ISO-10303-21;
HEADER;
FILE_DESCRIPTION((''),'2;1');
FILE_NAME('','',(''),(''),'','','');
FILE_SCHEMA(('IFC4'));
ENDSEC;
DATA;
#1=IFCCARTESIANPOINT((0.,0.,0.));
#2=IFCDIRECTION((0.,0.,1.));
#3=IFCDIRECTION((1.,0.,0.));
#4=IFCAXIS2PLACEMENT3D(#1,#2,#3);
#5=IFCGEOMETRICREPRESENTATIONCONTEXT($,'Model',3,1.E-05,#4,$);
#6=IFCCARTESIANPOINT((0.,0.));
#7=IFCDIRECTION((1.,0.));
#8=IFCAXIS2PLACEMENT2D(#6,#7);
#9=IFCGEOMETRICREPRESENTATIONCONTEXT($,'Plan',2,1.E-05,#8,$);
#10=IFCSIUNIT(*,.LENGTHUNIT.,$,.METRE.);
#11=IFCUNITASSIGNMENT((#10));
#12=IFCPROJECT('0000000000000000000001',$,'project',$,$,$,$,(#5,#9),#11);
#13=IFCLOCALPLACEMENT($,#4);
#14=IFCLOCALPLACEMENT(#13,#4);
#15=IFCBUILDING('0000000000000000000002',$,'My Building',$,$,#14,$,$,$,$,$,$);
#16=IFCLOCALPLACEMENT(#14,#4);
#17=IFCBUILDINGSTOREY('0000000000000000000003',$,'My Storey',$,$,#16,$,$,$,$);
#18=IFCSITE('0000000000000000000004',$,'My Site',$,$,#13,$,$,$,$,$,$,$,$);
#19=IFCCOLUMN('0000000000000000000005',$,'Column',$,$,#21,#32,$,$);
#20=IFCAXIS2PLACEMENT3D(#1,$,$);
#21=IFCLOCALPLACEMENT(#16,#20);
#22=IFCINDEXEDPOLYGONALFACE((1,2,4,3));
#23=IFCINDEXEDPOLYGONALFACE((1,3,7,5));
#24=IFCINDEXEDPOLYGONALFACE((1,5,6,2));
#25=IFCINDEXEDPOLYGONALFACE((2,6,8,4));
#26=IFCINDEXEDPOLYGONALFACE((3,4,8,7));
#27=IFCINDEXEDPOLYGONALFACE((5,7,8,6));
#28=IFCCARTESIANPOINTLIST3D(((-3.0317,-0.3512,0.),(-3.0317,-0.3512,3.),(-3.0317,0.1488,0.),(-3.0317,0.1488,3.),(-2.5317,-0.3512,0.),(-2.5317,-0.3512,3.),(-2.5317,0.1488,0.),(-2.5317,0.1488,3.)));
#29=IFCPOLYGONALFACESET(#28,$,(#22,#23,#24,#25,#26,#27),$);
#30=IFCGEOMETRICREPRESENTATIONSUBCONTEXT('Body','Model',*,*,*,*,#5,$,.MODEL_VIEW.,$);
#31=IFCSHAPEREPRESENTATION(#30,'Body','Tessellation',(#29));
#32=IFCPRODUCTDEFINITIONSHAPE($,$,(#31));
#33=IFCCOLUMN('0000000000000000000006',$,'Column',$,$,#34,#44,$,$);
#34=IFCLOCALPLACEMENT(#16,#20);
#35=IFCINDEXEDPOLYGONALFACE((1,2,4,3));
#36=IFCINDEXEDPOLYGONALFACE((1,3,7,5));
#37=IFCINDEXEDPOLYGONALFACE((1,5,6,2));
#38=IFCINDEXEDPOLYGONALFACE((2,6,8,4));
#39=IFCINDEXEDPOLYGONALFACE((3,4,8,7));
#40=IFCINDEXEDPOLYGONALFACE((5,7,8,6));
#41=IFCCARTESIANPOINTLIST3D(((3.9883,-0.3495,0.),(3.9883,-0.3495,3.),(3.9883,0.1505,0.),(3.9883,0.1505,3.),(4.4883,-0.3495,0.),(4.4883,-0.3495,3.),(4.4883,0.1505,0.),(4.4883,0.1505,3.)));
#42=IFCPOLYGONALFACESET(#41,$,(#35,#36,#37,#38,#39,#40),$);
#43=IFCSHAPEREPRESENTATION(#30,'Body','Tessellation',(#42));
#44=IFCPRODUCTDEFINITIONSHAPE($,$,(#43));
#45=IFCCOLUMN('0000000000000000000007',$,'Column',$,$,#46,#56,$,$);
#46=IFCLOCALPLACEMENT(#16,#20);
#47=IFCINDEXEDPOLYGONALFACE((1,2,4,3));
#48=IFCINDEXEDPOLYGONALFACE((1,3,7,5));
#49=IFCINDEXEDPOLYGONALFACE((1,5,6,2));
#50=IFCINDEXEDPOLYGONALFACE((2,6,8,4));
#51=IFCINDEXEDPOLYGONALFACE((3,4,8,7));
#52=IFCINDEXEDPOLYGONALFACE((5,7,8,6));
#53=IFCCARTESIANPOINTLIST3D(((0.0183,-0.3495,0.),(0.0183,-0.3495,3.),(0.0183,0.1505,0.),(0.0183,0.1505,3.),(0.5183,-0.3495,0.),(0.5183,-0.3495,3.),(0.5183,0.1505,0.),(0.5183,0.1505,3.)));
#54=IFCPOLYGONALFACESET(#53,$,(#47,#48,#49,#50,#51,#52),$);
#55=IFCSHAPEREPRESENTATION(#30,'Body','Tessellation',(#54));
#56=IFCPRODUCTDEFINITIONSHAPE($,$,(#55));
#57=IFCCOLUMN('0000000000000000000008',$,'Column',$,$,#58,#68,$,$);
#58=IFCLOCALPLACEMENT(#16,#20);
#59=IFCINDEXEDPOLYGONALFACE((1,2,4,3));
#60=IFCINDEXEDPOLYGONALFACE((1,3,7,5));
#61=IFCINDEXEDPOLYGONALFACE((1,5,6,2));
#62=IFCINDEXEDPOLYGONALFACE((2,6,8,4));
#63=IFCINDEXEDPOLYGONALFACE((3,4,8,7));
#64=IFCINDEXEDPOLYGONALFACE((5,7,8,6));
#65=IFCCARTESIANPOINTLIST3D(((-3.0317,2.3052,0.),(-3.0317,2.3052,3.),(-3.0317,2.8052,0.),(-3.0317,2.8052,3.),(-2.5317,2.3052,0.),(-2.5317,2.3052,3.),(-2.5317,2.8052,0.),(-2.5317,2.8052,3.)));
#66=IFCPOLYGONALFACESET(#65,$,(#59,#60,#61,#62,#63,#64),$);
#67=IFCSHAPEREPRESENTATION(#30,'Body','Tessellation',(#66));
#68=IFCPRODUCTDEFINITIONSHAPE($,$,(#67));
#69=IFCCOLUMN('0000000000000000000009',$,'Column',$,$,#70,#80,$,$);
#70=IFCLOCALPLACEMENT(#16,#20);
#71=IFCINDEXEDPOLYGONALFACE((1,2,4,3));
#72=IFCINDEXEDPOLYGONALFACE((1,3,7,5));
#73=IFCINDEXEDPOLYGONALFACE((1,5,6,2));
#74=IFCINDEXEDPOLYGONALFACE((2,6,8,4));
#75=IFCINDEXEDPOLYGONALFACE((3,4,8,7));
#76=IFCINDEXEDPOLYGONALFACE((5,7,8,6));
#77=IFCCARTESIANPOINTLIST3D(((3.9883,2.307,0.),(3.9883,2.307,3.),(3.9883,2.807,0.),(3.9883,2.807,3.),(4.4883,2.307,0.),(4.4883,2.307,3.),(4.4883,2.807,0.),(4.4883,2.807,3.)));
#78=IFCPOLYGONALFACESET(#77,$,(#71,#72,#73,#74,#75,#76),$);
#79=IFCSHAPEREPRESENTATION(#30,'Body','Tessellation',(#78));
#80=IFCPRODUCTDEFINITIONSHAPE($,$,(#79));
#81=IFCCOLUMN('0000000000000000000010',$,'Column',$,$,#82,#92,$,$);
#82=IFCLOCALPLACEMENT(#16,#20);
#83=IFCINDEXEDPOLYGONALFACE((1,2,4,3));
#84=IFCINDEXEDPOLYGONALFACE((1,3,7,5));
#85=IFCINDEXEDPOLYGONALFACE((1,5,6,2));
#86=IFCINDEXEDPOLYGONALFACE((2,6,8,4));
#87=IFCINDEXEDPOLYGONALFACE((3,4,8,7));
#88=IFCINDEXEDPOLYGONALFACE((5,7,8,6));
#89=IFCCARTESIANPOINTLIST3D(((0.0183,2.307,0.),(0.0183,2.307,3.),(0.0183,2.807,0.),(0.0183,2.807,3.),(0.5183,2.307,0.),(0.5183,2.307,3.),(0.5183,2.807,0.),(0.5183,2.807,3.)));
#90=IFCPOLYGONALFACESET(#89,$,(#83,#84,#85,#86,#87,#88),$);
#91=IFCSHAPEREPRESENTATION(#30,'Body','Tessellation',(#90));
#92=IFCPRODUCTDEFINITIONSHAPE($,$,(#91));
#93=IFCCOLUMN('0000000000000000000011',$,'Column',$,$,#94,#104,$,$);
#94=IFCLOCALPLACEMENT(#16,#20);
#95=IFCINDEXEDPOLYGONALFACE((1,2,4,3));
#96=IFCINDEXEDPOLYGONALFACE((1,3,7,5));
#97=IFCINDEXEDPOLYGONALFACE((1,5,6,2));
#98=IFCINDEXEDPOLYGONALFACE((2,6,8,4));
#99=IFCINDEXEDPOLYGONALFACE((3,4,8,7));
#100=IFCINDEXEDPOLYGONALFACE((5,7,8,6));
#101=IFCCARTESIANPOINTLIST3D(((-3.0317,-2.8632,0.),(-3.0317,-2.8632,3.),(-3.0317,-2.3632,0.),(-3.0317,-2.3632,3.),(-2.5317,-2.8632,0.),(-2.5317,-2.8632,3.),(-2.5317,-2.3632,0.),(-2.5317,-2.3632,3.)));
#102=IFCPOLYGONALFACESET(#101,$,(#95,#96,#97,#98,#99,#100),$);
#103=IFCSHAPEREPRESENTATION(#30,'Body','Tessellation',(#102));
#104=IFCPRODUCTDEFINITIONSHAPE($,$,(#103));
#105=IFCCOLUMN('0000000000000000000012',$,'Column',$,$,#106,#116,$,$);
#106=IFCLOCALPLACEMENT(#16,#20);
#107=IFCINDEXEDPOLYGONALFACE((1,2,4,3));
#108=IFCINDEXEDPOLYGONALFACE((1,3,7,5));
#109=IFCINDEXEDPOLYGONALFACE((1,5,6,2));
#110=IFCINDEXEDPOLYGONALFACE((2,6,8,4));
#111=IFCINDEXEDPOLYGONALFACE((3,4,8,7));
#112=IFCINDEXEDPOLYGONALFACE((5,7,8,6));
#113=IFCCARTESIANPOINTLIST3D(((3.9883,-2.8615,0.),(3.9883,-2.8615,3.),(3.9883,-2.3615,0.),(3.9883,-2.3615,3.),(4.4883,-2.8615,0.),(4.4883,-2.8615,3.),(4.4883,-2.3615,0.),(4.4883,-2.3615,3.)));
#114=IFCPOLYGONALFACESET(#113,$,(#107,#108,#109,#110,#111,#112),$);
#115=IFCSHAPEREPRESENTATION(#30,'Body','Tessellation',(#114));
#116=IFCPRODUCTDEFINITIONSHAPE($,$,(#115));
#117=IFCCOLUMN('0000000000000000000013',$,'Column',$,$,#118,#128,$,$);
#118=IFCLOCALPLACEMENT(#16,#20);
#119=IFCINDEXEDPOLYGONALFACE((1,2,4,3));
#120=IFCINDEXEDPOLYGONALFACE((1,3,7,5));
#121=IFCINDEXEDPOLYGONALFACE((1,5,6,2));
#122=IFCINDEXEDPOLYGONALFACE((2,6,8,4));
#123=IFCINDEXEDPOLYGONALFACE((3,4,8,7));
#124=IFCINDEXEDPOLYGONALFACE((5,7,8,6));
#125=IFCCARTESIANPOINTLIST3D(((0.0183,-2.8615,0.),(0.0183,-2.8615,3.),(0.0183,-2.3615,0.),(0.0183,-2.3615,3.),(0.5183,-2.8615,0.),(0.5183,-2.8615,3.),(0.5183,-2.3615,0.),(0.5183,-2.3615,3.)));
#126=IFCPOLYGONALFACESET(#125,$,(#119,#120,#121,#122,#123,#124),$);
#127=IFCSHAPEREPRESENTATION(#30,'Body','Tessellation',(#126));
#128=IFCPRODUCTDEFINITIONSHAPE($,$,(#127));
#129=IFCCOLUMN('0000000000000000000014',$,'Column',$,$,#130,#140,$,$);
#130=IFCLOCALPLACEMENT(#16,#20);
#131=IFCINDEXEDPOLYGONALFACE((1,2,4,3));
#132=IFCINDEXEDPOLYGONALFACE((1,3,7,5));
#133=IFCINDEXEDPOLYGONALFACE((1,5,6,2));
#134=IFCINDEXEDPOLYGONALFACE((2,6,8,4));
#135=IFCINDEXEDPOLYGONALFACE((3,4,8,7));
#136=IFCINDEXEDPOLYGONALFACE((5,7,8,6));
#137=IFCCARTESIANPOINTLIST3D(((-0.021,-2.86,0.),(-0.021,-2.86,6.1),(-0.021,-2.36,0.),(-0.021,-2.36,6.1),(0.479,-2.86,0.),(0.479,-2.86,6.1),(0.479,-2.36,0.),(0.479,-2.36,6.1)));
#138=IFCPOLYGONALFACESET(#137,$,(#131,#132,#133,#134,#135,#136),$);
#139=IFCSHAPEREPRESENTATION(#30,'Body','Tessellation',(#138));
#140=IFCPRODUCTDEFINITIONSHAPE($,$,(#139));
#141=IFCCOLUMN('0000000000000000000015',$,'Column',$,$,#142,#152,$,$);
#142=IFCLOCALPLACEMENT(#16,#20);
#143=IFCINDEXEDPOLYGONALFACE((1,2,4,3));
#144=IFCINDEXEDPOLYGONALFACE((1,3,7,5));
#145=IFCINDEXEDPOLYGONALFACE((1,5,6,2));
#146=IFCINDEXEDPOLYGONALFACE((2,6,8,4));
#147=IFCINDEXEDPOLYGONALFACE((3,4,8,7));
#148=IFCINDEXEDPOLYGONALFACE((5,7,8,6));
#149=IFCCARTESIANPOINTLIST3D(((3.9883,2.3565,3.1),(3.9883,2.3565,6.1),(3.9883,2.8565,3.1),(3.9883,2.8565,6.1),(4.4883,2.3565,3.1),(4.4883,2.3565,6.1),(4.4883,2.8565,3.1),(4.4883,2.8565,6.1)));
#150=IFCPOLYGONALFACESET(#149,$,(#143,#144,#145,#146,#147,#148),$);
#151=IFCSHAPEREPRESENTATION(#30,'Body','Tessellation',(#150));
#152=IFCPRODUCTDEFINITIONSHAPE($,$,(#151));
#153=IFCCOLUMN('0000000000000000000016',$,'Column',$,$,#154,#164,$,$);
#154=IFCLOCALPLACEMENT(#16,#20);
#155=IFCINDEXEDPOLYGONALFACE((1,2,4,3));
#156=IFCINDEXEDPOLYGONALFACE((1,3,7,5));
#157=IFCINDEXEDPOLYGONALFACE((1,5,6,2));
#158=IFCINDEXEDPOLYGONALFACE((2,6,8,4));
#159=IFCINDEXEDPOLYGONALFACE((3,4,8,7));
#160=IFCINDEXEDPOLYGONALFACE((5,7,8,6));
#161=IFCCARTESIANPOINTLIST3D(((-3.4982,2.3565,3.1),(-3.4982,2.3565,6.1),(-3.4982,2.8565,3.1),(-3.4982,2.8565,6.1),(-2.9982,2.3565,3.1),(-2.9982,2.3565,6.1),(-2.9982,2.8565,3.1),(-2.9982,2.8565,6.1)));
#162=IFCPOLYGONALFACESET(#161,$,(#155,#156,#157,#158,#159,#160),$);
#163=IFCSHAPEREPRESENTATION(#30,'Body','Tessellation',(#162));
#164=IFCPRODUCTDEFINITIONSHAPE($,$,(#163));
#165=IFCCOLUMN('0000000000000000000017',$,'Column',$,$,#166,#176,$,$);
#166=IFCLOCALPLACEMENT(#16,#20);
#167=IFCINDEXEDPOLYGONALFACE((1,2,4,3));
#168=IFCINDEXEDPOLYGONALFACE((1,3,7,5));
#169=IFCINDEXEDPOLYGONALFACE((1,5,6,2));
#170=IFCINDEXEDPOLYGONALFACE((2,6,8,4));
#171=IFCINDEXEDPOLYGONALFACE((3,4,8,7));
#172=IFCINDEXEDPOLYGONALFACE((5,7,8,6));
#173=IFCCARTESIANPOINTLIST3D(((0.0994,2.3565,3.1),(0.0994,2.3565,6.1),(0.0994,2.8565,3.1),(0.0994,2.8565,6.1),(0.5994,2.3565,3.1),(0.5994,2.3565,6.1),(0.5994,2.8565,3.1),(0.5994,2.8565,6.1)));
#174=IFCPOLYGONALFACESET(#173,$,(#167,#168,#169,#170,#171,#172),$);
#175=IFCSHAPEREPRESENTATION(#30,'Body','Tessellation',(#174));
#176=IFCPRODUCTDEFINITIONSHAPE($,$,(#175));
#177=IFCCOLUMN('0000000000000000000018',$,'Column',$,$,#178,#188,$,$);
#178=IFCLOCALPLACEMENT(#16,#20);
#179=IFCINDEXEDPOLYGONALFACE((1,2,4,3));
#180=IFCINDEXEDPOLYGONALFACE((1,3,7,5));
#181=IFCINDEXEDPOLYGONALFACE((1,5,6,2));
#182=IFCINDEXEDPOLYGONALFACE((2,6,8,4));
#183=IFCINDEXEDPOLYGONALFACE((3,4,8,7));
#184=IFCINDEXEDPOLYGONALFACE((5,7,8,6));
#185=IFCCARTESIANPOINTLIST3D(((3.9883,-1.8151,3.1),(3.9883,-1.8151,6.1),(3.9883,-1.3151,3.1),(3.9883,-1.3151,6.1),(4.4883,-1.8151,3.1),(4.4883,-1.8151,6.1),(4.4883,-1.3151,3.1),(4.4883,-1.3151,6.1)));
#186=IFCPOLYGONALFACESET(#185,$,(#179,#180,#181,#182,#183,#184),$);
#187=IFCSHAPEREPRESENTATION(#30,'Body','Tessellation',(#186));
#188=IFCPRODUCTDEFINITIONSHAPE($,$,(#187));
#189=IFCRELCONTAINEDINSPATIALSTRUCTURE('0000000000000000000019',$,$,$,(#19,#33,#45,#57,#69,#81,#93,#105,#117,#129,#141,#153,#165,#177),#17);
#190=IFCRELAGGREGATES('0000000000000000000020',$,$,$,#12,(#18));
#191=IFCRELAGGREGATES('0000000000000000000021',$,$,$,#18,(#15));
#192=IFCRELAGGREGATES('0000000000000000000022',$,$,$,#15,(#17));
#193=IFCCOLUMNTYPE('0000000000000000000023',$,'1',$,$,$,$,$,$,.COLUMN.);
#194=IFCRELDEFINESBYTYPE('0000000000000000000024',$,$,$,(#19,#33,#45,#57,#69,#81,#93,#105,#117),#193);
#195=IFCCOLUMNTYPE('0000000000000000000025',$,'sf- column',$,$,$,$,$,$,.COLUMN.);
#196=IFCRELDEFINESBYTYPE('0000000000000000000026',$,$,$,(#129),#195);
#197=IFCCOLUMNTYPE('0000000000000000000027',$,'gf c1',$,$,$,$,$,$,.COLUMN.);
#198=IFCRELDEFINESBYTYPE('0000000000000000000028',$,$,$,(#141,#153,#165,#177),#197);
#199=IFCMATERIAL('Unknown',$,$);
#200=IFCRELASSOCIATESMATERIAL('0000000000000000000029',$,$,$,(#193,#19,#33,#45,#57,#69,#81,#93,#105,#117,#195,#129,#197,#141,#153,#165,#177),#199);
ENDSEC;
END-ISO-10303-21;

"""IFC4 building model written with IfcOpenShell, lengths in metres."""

from ifc_helpers import new_model, si_unit, frame, origin_with_axes, origin_2d_with_axis, place, context, subcontext, project, spatial, rectangle, extrude, material, material_profile, profile_set, profile_usage, type_object, element, save


model = new_model("IFC4")

# Units and contexts
model_context = context("Model", 3, precision=1e-05, world=origin_with_axes())
plan_context = context("Plan", 2, precision=1e-05, world=origin_2d_with_axis())
body_context = subcontext(model_context, "Body", "Model", "MODEL_VIEW")
ifc_project = project(units=[si_unit("LENGTHUNIT", "METRE")], contexts=[model_context, plan_context])

# Site, building, storey
site_placement = place(None, origin_with_axes())
site = spatial("IfcSite", under=ifc_project, at=site_placement, Name="My Site")
building_placement = place(site_placement, origin_with_axes())
building = spatial("IfcBuilding", under=site, at=building_placement, Name="My Building")
storey_placement = place(building_placement, origin_with_axes())
storey = spatial("IfcBuildingStorey", under=building, at=storey_placement, Name="My Storey")

# Columns
ifc_material = material(Name="Unknown")
ifc_material_profile_1 = material_profile(ifc_material, rectangle(XDim=0.5, YDim=0.5))
ifc_profile_set_1 = profile_set([ifc_material_profile_1])
ifc_profile_usage_1 = profile_usage(ifc_profile_set_1, cardinal=5)
column_type_1 = type_object("IfcColumnType", Name="1", PredefinedType="COLUMN", material=ifc_profile_set_1)
column_1_placement = place(storey_placement, frame((-2.7817, -0.1012, 0.0), z_axis=(0.0, 0.0, 1.0), x_axis=(1.0, 0.0, 0.0)))
element("IfcColumn", 1, at=column_1_placement, inside=storey, type_object=column_type_1, material=ifc_profile_usage_1, Name="Column", context=body_context, shape_type="SweptSolid", body=[
    extrude(rectangle(XDim=0.5, YDim=0.5), origin_with_axes(), (0.0, 0.0, 1.0), 3.0),
])
ifc_profile_usage_2 = profile_usage(ifc_profile_set_1, cardinal=5)
column_2_placement = place(storey_placement, frame((4.2383, -0.0995, 0.0), z_axis=(0.0, 0.0, 1.0), x_axis=(1.0, 0.0, 0.0)))
element("IfcColumn", 2, at=column_2_placement, inside=storey, type_object=column_type_1, material=ifc_profile_usage_2, Name="Column", context=body_context, shape_type="SweptSolid", body=[
    extrude(rectangle(XDim=0.5, YDim=0.5), origin_with_axes(), (0.0, 0.0, 1.0), 3.0),
])
ifc_profile_usage_3 = profile_usage(ifc_profile_set_1, cardinal=5)
column_3_placement = place(storey_placement, frame((0.2683, -0.0995, 0.0), z_axis=(0.0, 0.0, 1.0), x_axis=(1.0, 0.0, 0.0)))
element("IfcColumn", 3, at=column_3_placement, inside=storey, type_object=column_type_1, material=ifc_profile_usage_3, Name="Column", context=body_context, shape_type="SweptSolid", body=[
    extrude(rectangle(XDim=0.5, YDim=0.5), origin_with_axes(), (0.0, 0.0, 1.0), 3.0),
])
ifc_profile_usage_4 = profile_usage(ifc_profile_set_1, cardinal=5)
column_4_placement = place(storey_placement, frame((-2.7817, 2.5552, 0.0), z_axis=(0.0, 0.0, 1.0), x_axis=(1.0, 0.0, 0.0)))
element("IfcColumn", 4, at=column_4_placement, inside=storey, type_object=column_type_1, material=ifc_profile_usage_4, Name="Column", context=body_context, shape_type="SweptSolid", body=[
    extrude(rectangle(XDim=0.5, YDim=0.5), origin_with_axes(), (0.0, 0.0, 1.0), 3.0),
])
ifc_profile_usage_5 = profile_usage(ifc_profile_set_1, cardinal=5)
column_5_placement = place(storey_placement, frame((4.2383, 2.557, 0.0), z_axis=(0.0, 0.0, 1.0), x_axis=(1.0, 0.0, 0.0)))
element("IfcColumn", 5, at=column_5_placement, inside=storey, type_object=column_type_1, material=ifc_profile_usage_5, Name="Column", context=body_context, shape_type="SweptSolid", body=[
    extrude(rectangle(XDim=0.5, YDim=0.5), origin_with_axes(), (0.0, 0.0, 1.0), 3.0),
])
ifc_profile_usage_6 = profile_usage(ifc_profile_set_1, cardinal=5)
column_6_placement = place(storey_placement, frame((0.2683, 2.557, 0.0), z_axis=(0.0, 0.0, 1.0), x_axis=(1.0, 0.0, 0.0)))
element("IfcColumn", 6, at=column_6_placement, inside=storey, type_object=column_type_1, material=ifc_profile_usage_6, Name="Column", context=body_context, shape_type="SweptSolid", body=[
    extrude(rectangle(XDim=0.5, YDim=0.5), origin_with_axes(), (0.0, 0.0, 1.0), 3.0),
])
ifc_profile_usage_7 = profile_usage(ifc_profile_set_1, cardinal=5)
column_7_placement = place(storey_placement, frame((-2.7817, -2.6132, 0.0), z_axis=(0.0, 0.0, 1.0), x_axis=(1.0, 0.0, 0.0)))
element("IfcColumn", 7, at=column_7_placement, inside=storey, type_object=column_type_1, material=ifc_profile_usage_7, Name="Column", context=body_context, shape_type="SweptSolid", body=[
    extrude(rectangle(XDim=0.5, YDim=0.5), origin_with_axes(), (0.0, 0.0, 1.0), 3.0),
])
ifc_profile_usage_8 = profile_usage(ifc_profile_set_1, cardinal=5)
column_8_placement = place(storey_placement, frame((4.2383, -2.6115, 0.0), z_axis=(0.0, 0.0, 1.0), x_axis=(1.0, 0.0, 0.0)))
element("IfcColumn", 8, at=column_8_placement, inside=storey, type_object=column_type_1, material=ifc_profile_usage_8, Name="Column", context=body_context, shape_type="SweptSolid", body=[
    extrude(rectangle(XDim=0.5, YDim=0.5), origin_with_axes(), (0.0, 0.0, 1.0), 3.0),
])
ifc_profile_usage_9 = profile_usage(ifc_profile_set_1, cardinal=5)
column_9_placement = place(storey_placement, frame((0.2683, -2.6115, 0.0), z_axis=(0.0, 0.0, 1.0), x_axis=(1.0, 0.0, 0.0)))
element("IfcColumn", 9, at=column_9_placement, inside=storey, type_object=column_type_1, material=ifc_profile_usage_9, Name="Column", context=body_context, shape_type="SweptSolid", body=[
    extrude(rectangle(XDim=0.5, YDim=0.5), origin_with_axes(), (0.0, 0.0, 1.0), 3.0),
])
ifc_material_profile_2 = material_profile(ifc_material, rectangle(XDim=0.5, YDim=0.5))
ifc_profile_set_2 = profile_set([ifc_material_profile_2])
ifc_profile_usage_10 = profile_usage(ifc_profile_set_2, cardinal=5)
column_type_2 = type_object("IfcColumnType", Name="sf- column", PredefinedType="COLUMN", material=ifc_profile_set_2)
column_10_placement = place(storey_placement, frame((0.229, -2.61, 0.0), z_axis=(0.0, 0.0, 1.0), x_axis=(1.0, 0.0, 0.0)))
element("IfcColumn", 10, at=column_10_placement, inside=storey, type_object=column_type_2, material=ifc_profile_usage_10, Name="Column", context=body_context, shape_type="SweptSolid", body=[
    extrude(rectangle(XDim=0.5, YDim=0.5), origin_with_axes(), (0.0, 0.0, 1.0), 6.1),
])
ifc_material_profile_3 = material_profile(ifc_material, rectangle(XDim=0.5, YDim=0.5))
ifc_profile_set_3 = profile_set([ifc_material_profile_3])
ifc_profile_usage_11 = profile_usage(ifc_profile_set_3, cardinal=5)
column_type_3 = type_object("IfcColumnType", Name="gf c1", PredefinedType="COLUMN", material=ifc_profile_set_3)
column_11_placement = place(storey_placement, frame((4.2383, 2.6065, 3.1), z_axis=(0.0, 0.0, 1.0), x_axis=(1.0, 0.0, 0.0)))
element("IfcColumn", 11, at=column_11_placement, inside=storey, type_object=column_type_3, material=ifc_profile_usage_11, Name="Column", context=body_context, shape_type="SweptSolid", body=[
    extrude(rectangle(XDim=0.5, YDim=0.5), origin_with_axes(), (0.0, 0.0, 1.0), 3.0),
])
ifc_profile_usage_12 = profile_usage(ifc_profile_set_3, cardinal=5)
column_12_placement = place(storey_placement, frame((-3.2482, 2.6065, 3.1), z_axis=(0.0, 0.0, 1.0), x_axis=(1.0, 0.0, 0.0)))
element("IfcColumn", 12, at=column_12_placement, inside=storey, type_object=column_type_3, material=ifc_profile_usage_12, Name="Column", context=body_context, shape_type="SweptSolid", body=[
    extrude(rectangle(XDim=0.5, YDim=0.5), origin_with_axes(), (0.0, 0.0, 1.0), 3.0),
])
ifc_profile_usage_13 = profile_usage(ifc_profile_set_3, cardinal=5)
column_13_placement = place(storey_placement, frame((0.3494, 2.6065, 3.1), z_axis=(0.0, 0.0, 1.0), x_axis=(1.0, 0.0, 0.0)))
element("IfcColumn", 13, at=column_13_placement, inside=storey, type_object=column_type_3, material=ifc_profile_usage_13, Name="Column", context=body_context, shape_type="SweptSolid", body=[
    extrude(rectangle(XDim=0.5, YDim=0.5), origin_with_axes(), (0.0, 0.0, 1.0), 3.0),
])
ifc_profile_usage_14 = profile_usage(ifc_profile_set_3, cardinal=5)
column_14_placement = place(storey_placement, frame((4.2383, -1.5651, 3.1), z_axis=(0.0, 0.0, 1.0), x_axis=(1.0, 0.0, 0.0)))
element("IfcColumn", 14, at=column_14_placement, inside=storey, type_object=column_type_3, material=ifc_profile_usage_14, Name="Column", context=body_context, shape_type="SweptSolid", body=[
    extrude(rectangle(XDim=0.5, YDim=0.5), origin_with_axes(), (0.0, 0.0, 1.0), 3.0),
])

save(model, "model.ifc")
